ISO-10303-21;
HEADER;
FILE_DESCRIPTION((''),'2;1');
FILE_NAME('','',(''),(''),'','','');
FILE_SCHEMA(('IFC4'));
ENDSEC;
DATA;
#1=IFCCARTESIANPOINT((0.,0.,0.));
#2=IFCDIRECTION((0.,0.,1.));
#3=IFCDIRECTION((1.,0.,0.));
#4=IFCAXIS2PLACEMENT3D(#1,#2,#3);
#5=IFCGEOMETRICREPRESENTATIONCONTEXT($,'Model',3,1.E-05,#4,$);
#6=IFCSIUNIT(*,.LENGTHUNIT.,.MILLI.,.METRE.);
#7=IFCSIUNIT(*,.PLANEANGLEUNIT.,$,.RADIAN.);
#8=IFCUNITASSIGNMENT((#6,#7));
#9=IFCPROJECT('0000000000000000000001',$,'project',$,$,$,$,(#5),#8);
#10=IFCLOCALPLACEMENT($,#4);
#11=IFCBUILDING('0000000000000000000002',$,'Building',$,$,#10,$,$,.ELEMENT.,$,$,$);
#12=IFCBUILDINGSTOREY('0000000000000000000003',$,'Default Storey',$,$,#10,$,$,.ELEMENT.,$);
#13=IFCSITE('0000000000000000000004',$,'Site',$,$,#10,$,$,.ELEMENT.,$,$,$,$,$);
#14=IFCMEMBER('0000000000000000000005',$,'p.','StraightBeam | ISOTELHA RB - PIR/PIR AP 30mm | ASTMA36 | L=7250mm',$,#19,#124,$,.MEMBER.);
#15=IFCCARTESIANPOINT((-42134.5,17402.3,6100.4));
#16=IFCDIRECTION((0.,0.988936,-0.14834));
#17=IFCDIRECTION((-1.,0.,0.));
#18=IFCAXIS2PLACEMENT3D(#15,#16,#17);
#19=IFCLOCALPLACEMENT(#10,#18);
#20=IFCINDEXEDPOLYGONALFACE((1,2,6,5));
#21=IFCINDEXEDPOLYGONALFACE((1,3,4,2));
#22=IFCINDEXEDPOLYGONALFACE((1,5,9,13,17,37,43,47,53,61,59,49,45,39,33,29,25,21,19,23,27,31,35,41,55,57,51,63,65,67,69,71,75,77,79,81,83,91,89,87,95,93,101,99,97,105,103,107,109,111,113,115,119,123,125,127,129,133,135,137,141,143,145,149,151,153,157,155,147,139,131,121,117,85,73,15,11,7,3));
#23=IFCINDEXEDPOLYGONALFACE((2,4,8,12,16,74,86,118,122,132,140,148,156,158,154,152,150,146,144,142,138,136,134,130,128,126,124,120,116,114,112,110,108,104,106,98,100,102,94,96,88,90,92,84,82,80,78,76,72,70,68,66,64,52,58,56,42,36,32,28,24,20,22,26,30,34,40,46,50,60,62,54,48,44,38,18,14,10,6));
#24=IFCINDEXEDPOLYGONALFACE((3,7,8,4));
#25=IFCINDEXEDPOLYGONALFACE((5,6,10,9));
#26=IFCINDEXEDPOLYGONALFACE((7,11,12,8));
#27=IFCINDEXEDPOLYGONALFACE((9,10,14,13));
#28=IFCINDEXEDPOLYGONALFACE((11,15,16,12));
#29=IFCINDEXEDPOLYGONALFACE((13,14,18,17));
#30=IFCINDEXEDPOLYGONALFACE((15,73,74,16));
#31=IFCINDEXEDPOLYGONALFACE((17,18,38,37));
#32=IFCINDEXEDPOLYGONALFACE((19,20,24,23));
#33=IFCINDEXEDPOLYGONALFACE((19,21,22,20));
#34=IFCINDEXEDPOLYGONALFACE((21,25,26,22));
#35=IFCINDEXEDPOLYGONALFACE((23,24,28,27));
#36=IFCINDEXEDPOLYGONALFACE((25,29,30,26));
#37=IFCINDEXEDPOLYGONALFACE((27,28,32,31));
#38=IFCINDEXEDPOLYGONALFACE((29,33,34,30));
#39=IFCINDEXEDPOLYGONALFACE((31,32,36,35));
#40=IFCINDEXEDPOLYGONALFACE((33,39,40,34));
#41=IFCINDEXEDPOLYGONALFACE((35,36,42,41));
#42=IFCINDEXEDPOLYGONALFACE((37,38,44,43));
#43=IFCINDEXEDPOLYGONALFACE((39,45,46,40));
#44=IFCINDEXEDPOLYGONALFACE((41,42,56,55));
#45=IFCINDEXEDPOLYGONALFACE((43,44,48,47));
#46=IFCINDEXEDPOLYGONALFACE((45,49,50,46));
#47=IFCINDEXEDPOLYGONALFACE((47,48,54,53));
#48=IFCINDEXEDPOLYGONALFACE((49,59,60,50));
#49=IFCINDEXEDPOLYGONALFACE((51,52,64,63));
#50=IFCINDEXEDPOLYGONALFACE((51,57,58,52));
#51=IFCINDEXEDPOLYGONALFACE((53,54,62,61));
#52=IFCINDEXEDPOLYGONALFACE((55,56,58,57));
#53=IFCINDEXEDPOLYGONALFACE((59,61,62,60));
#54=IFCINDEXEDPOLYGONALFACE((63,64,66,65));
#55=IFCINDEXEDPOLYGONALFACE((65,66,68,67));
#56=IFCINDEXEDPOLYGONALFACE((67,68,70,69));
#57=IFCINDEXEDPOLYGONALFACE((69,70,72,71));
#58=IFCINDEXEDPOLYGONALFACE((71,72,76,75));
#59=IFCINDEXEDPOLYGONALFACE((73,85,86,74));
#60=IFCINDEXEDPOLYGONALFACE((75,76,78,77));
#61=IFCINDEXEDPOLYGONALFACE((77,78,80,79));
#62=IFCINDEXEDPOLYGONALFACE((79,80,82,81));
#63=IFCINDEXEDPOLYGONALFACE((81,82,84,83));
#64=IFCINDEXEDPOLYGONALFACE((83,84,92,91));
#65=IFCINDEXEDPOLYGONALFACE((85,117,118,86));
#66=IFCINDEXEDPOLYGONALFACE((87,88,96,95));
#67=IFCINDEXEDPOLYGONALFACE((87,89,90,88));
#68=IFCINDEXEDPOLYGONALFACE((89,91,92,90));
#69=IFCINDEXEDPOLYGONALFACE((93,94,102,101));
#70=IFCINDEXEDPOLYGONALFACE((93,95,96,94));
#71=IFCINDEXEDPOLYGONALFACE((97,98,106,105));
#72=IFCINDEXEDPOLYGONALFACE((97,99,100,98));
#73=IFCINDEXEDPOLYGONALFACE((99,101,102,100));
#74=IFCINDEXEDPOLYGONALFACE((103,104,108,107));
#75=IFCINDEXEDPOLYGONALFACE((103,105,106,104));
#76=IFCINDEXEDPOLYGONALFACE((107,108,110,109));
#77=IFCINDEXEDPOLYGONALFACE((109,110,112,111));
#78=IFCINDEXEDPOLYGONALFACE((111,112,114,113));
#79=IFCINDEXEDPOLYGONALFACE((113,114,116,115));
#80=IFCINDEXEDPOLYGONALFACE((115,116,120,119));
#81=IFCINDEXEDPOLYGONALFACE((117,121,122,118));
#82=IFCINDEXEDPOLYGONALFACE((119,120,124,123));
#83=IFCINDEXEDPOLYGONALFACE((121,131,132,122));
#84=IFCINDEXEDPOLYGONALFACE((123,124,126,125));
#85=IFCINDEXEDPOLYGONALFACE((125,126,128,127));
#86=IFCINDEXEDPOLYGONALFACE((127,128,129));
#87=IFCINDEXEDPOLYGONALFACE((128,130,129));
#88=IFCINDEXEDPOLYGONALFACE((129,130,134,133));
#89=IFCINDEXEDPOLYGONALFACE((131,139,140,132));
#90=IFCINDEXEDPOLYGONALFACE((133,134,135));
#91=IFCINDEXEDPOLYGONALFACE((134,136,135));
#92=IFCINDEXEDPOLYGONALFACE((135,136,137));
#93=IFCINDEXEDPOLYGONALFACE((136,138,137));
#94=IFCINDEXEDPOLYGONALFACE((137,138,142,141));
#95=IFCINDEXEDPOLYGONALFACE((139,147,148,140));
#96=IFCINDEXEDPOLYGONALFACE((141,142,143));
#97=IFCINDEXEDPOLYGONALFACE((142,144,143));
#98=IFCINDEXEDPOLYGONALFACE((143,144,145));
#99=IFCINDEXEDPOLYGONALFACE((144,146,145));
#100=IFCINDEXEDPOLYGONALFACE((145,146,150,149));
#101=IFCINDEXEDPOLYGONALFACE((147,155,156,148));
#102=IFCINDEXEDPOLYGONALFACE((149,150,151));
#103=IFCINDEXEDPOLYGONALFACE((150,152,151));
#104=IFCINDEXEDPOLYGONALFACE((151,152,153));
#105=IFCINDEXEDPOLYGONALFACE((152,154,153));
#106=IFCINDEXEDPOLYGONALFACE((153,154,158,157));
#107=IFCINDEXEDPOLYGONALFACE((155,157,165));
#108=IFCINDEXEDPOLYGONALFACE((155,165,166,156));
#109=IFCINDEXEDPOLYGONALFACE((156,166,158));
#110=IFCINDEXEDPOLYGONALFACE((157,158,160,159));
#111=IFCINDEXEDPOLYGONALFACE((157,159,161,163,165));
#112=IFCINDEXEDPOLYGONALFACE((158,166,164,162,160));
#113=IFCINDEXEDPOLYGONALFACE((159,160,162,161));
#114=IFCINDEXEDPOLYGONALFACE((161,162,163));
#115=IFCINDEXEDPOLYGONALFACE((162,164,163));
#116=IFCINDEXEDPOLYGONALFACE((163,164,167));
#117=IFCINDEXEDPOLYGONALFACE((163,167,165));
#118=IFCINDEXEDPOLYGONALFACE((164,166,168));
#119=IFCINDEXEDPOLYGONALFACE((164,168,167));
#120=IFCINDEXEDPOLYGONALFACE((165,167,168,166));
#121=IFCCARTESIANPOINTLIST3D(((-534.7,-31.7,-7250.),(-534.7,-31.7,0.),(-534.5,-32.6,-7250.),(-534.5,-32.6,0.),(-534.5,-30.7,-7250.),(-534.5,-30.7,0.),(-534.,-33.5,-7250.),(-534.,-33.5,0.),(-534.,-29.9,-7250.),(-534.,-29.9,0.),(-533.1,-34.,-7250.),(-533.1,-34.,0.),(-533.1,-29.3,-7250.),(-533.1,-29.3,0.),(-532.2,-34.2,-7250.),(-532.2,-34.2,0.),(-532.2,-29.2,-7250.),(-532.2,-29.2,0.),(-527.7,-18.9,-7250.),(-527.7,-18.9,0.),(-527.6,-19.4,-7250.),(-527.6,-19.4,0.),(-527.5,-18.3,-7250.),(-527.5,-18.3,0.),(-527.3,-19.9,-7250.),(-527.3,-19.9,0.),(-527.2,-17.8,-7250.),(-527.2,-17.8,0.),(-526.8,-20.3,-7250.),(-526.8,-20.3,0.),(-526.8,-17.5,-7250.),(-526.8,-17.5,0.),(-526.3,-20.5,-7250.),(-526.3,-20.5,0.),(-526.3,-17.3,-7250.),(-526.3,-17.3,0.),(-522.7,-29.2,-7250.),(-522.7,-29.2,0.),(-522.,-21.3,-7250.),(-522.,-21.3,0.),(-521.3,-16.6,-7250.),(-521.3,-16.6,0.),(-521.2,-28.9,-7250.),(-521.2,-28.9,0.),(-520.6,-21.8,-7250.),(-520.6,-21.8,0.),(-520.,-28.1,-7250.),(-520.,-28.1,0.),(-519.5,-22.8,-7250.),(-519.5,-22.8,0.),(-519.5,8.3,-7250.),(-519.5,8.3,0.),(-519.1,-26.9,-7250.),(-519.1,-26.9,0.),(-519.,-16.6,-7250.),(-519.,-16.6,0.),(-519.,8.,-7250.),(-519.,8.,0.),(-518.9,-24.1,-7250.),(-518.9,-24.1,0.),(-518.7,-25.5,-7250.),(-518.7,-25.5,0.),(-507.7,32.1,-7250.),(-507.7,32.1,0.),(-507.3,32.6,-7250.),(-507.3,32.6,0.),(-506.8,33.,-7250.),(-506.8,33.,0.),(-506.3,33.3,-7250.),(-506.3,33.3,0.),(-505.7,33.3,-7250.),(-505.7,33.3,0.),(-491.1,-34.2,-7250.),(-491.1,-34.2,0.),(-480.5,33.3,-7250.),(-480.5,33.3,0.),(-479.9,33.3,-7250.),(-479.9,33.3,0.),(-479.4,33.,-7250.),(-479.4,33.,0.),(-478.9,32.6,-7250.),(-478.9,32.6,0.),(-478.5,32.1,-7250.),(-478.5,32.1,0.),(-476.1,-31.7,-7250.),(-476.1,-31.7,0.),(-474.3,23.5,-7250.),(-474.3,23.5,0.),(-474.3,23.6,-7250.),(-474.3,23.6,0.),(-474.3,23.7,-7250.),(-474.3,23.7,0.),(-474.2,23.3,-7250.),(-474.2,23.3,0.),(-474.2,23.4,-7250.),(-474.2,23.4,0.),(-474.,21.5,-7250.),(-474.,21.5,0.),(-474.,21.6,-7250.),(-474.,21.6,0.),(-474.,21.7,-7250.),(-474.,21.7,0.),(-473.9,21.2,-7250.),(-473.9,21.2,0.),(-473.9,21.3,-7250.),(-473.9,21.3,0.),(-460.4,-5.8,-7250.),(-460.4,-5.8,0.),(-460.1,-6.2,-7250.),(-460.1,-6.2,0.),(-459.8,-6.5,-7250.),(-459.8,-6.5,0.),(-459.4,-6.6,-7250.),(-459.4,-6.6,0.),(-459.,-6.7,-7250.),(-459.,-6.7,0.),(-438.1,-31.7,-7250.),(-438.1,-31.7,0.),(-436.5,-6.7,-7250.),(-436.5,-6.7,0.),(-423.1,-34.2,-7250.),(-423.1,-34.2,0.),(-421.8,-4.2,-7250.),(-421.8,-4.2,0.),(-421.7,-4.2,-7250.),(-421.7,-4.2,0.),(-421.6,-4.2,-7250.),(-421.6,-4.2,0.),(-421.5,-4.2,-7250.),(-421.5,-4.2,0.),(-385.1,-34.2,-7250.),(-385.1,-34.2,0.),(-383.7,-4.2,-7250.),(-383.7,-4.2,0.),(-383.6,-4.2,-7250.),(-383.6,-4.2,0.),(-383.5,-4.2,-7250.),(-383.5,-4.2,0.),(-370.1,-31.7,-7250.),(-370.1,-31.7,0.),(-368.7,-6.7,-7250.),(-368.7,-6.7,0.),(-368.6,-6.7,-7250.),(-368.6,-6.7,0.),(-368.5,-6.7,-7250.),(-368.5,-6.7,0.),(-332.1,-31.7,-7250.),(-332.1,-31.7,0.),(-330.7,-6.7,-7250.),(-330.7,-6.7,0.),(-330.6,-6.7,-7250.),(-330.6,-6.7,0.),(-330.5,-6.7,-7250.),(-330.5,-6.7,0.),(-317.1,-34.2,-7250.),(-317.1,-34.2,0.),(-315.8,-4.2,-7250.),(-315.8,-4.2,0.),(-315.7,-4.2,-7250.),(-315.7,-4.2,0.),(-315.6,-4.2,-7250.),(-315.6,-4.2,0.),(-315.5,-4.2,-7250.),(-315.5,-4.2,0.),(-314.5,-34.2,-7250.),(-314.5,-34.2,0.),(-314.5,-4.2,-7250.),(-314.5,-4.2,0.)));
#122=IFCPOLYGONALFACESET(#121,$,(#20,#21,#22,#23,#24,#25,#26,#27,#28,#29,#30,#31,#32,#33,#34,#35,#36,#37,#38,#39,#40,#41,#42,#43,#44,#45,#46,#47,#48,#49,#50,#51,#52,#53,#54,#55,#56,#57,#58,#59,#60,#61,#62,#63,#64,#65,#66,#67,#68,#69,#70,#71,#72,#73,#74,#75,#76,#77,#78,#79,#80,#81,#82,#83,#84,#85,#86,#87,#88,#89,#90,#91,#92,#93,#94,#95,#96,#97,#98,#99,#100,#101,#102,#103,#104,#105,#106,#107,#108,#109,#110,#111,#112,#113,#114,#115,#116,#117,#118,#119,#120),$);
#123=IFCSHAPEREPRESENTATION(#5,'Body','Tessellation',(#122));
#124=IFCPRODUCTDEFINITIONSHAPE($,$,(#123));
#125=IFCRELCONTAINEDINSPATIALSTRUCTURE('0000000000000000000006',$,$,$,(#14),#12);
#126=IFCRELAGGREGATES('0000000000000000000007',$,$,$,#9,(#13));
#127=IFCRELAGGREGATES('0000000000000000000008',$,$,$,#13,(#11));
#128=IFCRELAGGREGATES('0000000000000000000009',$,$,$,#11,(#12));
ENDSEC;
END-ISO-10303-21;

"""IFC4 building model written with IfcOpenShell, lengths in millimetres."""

from ifc_helpers import new_model, si_unit, frame, origin_with_axes, place, context, project, spatial, polyline, outline, extrude, element, save


model = new_model("IFC4")

# Units and contexts
model_context = context("Model", 3, precision=1e-05, world=origin_with_axes())
ifc_project = project(units=[si_unit("LENGTHUNIT", "METRE", prefix="MILLI"), si_unit("PLANEANGLEUNIT", "RADIAN")], contexts=[model_context])

# Site, building, storey
placement = place(None, origin_with_axes())
site = spatial("IfcSite", under=ifc_project, at=placement, Name="Site", CompositionType="ELEMENT")
building = spatial("IfcBuilding", under=site, at=placement, Name="Building", CompositionType="ELEMENT")
storey = spatial("IfcBuildingStorey", under=building, at=placement, Name="Default Storey", CompositionType="ELEMENT")

# Member, opening
member_1_placement = place(placement, frame((-42134.5, 17402.3, 6100.4), z_axis=(0.0, 0.988936, -0.14834), x_axis=(-1.0, 0.0, 0.0)))
member_1 = element("IfcMember", 1, at=member_1_placement, inside=storey, Name="p.", Description="StraightBeam | ISOTELHA RB - PIR/PIR AP 30mm | ASTMA36 | L=7250mm", PredefinedType="MEMBER", context=model_context, shape_type="SweptSolid", body=[
    extrude(outline(polyline([(-7.7, 33.3), (-8.3, 33.3), (-8.8, 33.0), (-9.3, 32.6), (-9.7, 32.1), (-28.4, -5.4), (-28.8, -5.9), (-29.3, -6.3), (-29.9, -6.6), (-30.5, -6.7), (-50.5, -6.7), (-50.5, -6.7), (-50.6, -6.7), (-50.7, -6.7), (-50.7, -6.7), (-65.5, -4.2), (-65.5, -4.2), (-65.6, -4.2), (-65.7, -4.2), (-65.7, -4.2), (-103.5, -4.2), (-103.5, -4.2), (-103.6, -4.2), (-103.7, -4.2), (-103.8, -4.2), (-118.5, -6.7), (-118.6, -6.7), (-118.6, -6.7), (-118.7, -6.7), (-118.7, -6.7), (-156.5, -6.7), (-156.5, -6.7), (-156.6, -6.7), (-156.7, -6.7), (-156.7, -6.7), (-171.5, -4.2), (-171.5, -4.2), (-171.6, -4.2), (-171.7, -4.2), (-171.7, -4.2), (-209.5, -4.2), (-209.5, -4.2), (-209.6, -4.2), (-209.7, -4.2), (-209.8, -4.2), (-224.5, -6.7), (-224.6, -6.7), (-224.6, -6.7), (-224.7, -6.7), (-224.7, -6.7), (-262.5, -6.7), (-262.5, -6.7), (-262.6, -6.7), (-262.7, -6.7), (-262.7, -6.7), (-277.5, -4.2), (-277.5, -4.2), (-277.6, -4.2), (-277.7, -4.2), (-277.7, -4.2), (-315.5, -4.2), (-315.5, -4.2), (-315.6, -4.2), (-315.7, -4.2), (-315.8, -4.2), (-330.5, -6.7), (-330.6, -6.7), (-330.6, -6.7), (-330.7, -6.7), (-330.7, -6.7), (-368.5, -6.7), (-368.5, -6.7), (-368.6, -6.7), (-368.7, -6.7), (-368.7, -6.7), (-383.5, -4.2), (-383.5, -4.2), (-383.6, -4.2), (-383.7, -4.2), (-383.7, -4.2), (-421.5, -4.2), (-421.5, -4.2), (-421.6, -4.2), (-421.7, -4.2), (-421.8, -4.2), (-436.5, -6.7), (-459.0, -6.7), (-459.4, -6.6), (-459.8, -6.5), (-460.1, -6.2), (-460.4, -5.8), (-473.9, 21.2), (-473.9, 21.3), (-474.0, 21.5), (-474.0, 21.6), (-474.0, 21.7), (-474.2, 23.3), (-474.2, 23.4), (-474.3, 23.5), (-474.3, 23.6), (-474.3, 23.7), (-478.5, 32.1), (-478.9, 32.6), (-479.4, 33.0), (-479.9, 33.3), (-480.5, 33.3), (-505.7, 33.3), (-506.3, 33.3), (-506.8, 33.0), (-507.3, 32.6), (-507.7, 32.1), (-519.5, 8.3), (-519.0, 8.0), (-519.0, -16.6), (-521.3, -16.6), (-526.3, -17.3), (-526.8, -17.5), (-527.2, -17.8), (-527.5, -18.3), (-527.7, -18.9), (-527.6, -19.4), (-527.3, -19.9), (-526.8, -20.3), (-526.3, -20.5), (-522.0, -21.3), (-520.6, -21.8), (-519.5, -22.8), (-518.9, -24.1), (-518.7, -25.5), (-519.1, -26.9), (-520.0, -28.1), (-521.2, -28.9), (-522.7, -29.2), (-532.2, -29.2), (-533.1, -29.3), (-534.0, -29.9), (-534.5, -30.7), (-534.7, -31.7), (-534.5, -32.6), (-534.0, -33.5), (-533.1, -34.0), (-532.2, -34.2), (-491.1, -34.2), (-476.1, -31.7), (-438.1, -31.7), (-423.1, -34.2), (-385.1, -34.2), (-370.1, -31.7), (-332.1, -31.7), (-317.1, -34.2), (-279.1, -34.2), (-264.1, -31.7), (-226.1, -31.7), (-211.1, -34.2), (-173.1, -34.2), (-158.1, -31.7), (-120.1, -31.7), (-105.1, -34.2), (-67.1, -34.2), (-52.1, -31.7), (-14.1, -31.7), (0.9, -34.2), (38.9, -34.2), (53.9, -31.7), (91.9, -31.7), (106.9, -34.2), (144.9, -34.2), (159.9, -31.7), (197.9, -31.7), (212.9, -34.2), (250.9, -34.2), (265.9, -31.7), (303.9, -31.7), (318.9, -34.2), (356.9, -34.2), (371.9, -31.7), (409.9, -31.7), (424.9, -34.2), (463.3, -34.2), (464.1, -34.0), (464.8, -33.6), (465.2, -33.0), (465.3, -32.2), (465.3, -30.8), (465.5, -30.0), (465.9, -29.4), (466.6, -29.0), (467.3, -28.8), (477.1, -28.8), (478.4, -28.6), (479.5, -27.9), (480.3, -26.8), (480.7, -25.6), (480.6, -24.3), (480.1, -23.1), (479.1, -22.2), (477.9, -21.6), (472.7, -20.4), (472.7, -2.7), (490.4, 32.8), (490.7, 33.2), (491.0, 33.5), (491.4, 33.6), (491.8, 33.7), (520.0, 33.7), (520.4, 33.6), (520.8, 33.5), (521.1, 33.2), (521.4, 32.8), (528.8, 18.0), (528.1, 17.6), (533.1, 7.6), (533.5, 7.2), (534.1, 7.3), (534.4, 7.7), (534.4, 8.3), (522.0, 33.1), (521.6, 33.6), (521.1, 34.0), (520.6, 34.3), (520.0, 34.3), (491.8, 34.3), (491.2, 34.3), (490.7, 34.0), (490.2, 33.6), (489.8, 33.1), (470.6, -5.4), (470.3, -5.9), (469.8, -6.3), (469.2, -6.6), (468.5, -6.7), (448.5, -6.7), (448.5, -6.7), (448.4, -6.7), (448.4, -6.7), (448.3, -6.7), (433.6, -4.2), (433.5, -4.2), (433.4, -4.2), (433.4, -4.2), (433.3, -4.2), (395.5, -4.2), (395.5, -4.2), (395.4, -4.2), (395.3, -4.2), (395.3, -4.2), (380.5, -6.7), (380.5, -6.7), (380.4, -6.7), (380.3, -6.7), (380.3, -6.7), (342.5, -6.7), (342.5, -6.7), (342.4, -6.7), (342.4, -6.7), (342.3, -6.7), (327.6, -4.2), (327.5, -4.2), (327.4, -4.2), (327.4, -4.2), (327.3, -4.2), (289.5, -4.2), (289.5, -4.2), (289.4, -4.2), (289.3, -4.2), (289.3, -4.2), (274.5, -6.7), (274.5, -6.7), (274.4, -6.7), (274.3, -6.7), (274.3, -6.7), (236.5, -6.7), (236.5, -6.7), (236.4, -6.7), (236.4, -6.7), (236.3, -6.7), (221.6, -4.2), (221.5, -4.2), (221.4, -4.2), (221.4, -4.2), (221.3, -4.2), (183.5, -4.2), (183.5, -4.2), (183.4, -4.2), (183.3, -4.2), (183.3, -4.2), (168.5, -6.7), (168.5, -6.7), (168.4, -6.7), (168.3, -6.7), (168.3, -6.7), (130.5, -6.7), (130.5, -6.7), (130.4, -6.7), (130.4, -6.7), (130.3, -6.7), (115.6, -4.2), (115.5, -4.2), (115.4, -4.2), (115.4, -4.2), (115.3, -4.2), (77.5, -4.2), (77.5, -4.2), (77.4, -4.2), (77.3, -4.2), (77.3, -4.2), (62.5, -6.7), (62.5, -6.7), (62.4, -6.7), (62.3, -6.7), (62.3, -6.7), (42.3, -6.7), (41.7, -6.6), (41.1, -6.3), (40.6, -5.9), (40.2, -5.4), (21.5, 32.1), (21.1, 32.6), (20.6, 33.0), (20.1, 33.3), (19.5, 33.3), (-7.7, 33.3)])), origin_with_axes(), (0.0, 0.0, -1.0), 7250.0),
])
opening_1_placement = place(member_1_placement, frame((0.0, -134.3, -7250.0), z_axis=(0.0, 1.0, 0.0), x_axis=(1.0, 0.0, 0.0)))
element("IfcOpeningElement", 2, at=opening_1_placement, cuts=member_1, PredefinedType="OPENING", context=model_context, shape_type="SweptSolid", body=[
    extrude(outline(polyline([(-314.5, 0.0), (-314.5, -7250.0), (634.6, -7250.0), (634.6, 0.0), (-314.5, 0.0)])), origin_with_axes(), (0.0, 0.0, 1.0), 268.8),
])

save(model, "model.ifc")
